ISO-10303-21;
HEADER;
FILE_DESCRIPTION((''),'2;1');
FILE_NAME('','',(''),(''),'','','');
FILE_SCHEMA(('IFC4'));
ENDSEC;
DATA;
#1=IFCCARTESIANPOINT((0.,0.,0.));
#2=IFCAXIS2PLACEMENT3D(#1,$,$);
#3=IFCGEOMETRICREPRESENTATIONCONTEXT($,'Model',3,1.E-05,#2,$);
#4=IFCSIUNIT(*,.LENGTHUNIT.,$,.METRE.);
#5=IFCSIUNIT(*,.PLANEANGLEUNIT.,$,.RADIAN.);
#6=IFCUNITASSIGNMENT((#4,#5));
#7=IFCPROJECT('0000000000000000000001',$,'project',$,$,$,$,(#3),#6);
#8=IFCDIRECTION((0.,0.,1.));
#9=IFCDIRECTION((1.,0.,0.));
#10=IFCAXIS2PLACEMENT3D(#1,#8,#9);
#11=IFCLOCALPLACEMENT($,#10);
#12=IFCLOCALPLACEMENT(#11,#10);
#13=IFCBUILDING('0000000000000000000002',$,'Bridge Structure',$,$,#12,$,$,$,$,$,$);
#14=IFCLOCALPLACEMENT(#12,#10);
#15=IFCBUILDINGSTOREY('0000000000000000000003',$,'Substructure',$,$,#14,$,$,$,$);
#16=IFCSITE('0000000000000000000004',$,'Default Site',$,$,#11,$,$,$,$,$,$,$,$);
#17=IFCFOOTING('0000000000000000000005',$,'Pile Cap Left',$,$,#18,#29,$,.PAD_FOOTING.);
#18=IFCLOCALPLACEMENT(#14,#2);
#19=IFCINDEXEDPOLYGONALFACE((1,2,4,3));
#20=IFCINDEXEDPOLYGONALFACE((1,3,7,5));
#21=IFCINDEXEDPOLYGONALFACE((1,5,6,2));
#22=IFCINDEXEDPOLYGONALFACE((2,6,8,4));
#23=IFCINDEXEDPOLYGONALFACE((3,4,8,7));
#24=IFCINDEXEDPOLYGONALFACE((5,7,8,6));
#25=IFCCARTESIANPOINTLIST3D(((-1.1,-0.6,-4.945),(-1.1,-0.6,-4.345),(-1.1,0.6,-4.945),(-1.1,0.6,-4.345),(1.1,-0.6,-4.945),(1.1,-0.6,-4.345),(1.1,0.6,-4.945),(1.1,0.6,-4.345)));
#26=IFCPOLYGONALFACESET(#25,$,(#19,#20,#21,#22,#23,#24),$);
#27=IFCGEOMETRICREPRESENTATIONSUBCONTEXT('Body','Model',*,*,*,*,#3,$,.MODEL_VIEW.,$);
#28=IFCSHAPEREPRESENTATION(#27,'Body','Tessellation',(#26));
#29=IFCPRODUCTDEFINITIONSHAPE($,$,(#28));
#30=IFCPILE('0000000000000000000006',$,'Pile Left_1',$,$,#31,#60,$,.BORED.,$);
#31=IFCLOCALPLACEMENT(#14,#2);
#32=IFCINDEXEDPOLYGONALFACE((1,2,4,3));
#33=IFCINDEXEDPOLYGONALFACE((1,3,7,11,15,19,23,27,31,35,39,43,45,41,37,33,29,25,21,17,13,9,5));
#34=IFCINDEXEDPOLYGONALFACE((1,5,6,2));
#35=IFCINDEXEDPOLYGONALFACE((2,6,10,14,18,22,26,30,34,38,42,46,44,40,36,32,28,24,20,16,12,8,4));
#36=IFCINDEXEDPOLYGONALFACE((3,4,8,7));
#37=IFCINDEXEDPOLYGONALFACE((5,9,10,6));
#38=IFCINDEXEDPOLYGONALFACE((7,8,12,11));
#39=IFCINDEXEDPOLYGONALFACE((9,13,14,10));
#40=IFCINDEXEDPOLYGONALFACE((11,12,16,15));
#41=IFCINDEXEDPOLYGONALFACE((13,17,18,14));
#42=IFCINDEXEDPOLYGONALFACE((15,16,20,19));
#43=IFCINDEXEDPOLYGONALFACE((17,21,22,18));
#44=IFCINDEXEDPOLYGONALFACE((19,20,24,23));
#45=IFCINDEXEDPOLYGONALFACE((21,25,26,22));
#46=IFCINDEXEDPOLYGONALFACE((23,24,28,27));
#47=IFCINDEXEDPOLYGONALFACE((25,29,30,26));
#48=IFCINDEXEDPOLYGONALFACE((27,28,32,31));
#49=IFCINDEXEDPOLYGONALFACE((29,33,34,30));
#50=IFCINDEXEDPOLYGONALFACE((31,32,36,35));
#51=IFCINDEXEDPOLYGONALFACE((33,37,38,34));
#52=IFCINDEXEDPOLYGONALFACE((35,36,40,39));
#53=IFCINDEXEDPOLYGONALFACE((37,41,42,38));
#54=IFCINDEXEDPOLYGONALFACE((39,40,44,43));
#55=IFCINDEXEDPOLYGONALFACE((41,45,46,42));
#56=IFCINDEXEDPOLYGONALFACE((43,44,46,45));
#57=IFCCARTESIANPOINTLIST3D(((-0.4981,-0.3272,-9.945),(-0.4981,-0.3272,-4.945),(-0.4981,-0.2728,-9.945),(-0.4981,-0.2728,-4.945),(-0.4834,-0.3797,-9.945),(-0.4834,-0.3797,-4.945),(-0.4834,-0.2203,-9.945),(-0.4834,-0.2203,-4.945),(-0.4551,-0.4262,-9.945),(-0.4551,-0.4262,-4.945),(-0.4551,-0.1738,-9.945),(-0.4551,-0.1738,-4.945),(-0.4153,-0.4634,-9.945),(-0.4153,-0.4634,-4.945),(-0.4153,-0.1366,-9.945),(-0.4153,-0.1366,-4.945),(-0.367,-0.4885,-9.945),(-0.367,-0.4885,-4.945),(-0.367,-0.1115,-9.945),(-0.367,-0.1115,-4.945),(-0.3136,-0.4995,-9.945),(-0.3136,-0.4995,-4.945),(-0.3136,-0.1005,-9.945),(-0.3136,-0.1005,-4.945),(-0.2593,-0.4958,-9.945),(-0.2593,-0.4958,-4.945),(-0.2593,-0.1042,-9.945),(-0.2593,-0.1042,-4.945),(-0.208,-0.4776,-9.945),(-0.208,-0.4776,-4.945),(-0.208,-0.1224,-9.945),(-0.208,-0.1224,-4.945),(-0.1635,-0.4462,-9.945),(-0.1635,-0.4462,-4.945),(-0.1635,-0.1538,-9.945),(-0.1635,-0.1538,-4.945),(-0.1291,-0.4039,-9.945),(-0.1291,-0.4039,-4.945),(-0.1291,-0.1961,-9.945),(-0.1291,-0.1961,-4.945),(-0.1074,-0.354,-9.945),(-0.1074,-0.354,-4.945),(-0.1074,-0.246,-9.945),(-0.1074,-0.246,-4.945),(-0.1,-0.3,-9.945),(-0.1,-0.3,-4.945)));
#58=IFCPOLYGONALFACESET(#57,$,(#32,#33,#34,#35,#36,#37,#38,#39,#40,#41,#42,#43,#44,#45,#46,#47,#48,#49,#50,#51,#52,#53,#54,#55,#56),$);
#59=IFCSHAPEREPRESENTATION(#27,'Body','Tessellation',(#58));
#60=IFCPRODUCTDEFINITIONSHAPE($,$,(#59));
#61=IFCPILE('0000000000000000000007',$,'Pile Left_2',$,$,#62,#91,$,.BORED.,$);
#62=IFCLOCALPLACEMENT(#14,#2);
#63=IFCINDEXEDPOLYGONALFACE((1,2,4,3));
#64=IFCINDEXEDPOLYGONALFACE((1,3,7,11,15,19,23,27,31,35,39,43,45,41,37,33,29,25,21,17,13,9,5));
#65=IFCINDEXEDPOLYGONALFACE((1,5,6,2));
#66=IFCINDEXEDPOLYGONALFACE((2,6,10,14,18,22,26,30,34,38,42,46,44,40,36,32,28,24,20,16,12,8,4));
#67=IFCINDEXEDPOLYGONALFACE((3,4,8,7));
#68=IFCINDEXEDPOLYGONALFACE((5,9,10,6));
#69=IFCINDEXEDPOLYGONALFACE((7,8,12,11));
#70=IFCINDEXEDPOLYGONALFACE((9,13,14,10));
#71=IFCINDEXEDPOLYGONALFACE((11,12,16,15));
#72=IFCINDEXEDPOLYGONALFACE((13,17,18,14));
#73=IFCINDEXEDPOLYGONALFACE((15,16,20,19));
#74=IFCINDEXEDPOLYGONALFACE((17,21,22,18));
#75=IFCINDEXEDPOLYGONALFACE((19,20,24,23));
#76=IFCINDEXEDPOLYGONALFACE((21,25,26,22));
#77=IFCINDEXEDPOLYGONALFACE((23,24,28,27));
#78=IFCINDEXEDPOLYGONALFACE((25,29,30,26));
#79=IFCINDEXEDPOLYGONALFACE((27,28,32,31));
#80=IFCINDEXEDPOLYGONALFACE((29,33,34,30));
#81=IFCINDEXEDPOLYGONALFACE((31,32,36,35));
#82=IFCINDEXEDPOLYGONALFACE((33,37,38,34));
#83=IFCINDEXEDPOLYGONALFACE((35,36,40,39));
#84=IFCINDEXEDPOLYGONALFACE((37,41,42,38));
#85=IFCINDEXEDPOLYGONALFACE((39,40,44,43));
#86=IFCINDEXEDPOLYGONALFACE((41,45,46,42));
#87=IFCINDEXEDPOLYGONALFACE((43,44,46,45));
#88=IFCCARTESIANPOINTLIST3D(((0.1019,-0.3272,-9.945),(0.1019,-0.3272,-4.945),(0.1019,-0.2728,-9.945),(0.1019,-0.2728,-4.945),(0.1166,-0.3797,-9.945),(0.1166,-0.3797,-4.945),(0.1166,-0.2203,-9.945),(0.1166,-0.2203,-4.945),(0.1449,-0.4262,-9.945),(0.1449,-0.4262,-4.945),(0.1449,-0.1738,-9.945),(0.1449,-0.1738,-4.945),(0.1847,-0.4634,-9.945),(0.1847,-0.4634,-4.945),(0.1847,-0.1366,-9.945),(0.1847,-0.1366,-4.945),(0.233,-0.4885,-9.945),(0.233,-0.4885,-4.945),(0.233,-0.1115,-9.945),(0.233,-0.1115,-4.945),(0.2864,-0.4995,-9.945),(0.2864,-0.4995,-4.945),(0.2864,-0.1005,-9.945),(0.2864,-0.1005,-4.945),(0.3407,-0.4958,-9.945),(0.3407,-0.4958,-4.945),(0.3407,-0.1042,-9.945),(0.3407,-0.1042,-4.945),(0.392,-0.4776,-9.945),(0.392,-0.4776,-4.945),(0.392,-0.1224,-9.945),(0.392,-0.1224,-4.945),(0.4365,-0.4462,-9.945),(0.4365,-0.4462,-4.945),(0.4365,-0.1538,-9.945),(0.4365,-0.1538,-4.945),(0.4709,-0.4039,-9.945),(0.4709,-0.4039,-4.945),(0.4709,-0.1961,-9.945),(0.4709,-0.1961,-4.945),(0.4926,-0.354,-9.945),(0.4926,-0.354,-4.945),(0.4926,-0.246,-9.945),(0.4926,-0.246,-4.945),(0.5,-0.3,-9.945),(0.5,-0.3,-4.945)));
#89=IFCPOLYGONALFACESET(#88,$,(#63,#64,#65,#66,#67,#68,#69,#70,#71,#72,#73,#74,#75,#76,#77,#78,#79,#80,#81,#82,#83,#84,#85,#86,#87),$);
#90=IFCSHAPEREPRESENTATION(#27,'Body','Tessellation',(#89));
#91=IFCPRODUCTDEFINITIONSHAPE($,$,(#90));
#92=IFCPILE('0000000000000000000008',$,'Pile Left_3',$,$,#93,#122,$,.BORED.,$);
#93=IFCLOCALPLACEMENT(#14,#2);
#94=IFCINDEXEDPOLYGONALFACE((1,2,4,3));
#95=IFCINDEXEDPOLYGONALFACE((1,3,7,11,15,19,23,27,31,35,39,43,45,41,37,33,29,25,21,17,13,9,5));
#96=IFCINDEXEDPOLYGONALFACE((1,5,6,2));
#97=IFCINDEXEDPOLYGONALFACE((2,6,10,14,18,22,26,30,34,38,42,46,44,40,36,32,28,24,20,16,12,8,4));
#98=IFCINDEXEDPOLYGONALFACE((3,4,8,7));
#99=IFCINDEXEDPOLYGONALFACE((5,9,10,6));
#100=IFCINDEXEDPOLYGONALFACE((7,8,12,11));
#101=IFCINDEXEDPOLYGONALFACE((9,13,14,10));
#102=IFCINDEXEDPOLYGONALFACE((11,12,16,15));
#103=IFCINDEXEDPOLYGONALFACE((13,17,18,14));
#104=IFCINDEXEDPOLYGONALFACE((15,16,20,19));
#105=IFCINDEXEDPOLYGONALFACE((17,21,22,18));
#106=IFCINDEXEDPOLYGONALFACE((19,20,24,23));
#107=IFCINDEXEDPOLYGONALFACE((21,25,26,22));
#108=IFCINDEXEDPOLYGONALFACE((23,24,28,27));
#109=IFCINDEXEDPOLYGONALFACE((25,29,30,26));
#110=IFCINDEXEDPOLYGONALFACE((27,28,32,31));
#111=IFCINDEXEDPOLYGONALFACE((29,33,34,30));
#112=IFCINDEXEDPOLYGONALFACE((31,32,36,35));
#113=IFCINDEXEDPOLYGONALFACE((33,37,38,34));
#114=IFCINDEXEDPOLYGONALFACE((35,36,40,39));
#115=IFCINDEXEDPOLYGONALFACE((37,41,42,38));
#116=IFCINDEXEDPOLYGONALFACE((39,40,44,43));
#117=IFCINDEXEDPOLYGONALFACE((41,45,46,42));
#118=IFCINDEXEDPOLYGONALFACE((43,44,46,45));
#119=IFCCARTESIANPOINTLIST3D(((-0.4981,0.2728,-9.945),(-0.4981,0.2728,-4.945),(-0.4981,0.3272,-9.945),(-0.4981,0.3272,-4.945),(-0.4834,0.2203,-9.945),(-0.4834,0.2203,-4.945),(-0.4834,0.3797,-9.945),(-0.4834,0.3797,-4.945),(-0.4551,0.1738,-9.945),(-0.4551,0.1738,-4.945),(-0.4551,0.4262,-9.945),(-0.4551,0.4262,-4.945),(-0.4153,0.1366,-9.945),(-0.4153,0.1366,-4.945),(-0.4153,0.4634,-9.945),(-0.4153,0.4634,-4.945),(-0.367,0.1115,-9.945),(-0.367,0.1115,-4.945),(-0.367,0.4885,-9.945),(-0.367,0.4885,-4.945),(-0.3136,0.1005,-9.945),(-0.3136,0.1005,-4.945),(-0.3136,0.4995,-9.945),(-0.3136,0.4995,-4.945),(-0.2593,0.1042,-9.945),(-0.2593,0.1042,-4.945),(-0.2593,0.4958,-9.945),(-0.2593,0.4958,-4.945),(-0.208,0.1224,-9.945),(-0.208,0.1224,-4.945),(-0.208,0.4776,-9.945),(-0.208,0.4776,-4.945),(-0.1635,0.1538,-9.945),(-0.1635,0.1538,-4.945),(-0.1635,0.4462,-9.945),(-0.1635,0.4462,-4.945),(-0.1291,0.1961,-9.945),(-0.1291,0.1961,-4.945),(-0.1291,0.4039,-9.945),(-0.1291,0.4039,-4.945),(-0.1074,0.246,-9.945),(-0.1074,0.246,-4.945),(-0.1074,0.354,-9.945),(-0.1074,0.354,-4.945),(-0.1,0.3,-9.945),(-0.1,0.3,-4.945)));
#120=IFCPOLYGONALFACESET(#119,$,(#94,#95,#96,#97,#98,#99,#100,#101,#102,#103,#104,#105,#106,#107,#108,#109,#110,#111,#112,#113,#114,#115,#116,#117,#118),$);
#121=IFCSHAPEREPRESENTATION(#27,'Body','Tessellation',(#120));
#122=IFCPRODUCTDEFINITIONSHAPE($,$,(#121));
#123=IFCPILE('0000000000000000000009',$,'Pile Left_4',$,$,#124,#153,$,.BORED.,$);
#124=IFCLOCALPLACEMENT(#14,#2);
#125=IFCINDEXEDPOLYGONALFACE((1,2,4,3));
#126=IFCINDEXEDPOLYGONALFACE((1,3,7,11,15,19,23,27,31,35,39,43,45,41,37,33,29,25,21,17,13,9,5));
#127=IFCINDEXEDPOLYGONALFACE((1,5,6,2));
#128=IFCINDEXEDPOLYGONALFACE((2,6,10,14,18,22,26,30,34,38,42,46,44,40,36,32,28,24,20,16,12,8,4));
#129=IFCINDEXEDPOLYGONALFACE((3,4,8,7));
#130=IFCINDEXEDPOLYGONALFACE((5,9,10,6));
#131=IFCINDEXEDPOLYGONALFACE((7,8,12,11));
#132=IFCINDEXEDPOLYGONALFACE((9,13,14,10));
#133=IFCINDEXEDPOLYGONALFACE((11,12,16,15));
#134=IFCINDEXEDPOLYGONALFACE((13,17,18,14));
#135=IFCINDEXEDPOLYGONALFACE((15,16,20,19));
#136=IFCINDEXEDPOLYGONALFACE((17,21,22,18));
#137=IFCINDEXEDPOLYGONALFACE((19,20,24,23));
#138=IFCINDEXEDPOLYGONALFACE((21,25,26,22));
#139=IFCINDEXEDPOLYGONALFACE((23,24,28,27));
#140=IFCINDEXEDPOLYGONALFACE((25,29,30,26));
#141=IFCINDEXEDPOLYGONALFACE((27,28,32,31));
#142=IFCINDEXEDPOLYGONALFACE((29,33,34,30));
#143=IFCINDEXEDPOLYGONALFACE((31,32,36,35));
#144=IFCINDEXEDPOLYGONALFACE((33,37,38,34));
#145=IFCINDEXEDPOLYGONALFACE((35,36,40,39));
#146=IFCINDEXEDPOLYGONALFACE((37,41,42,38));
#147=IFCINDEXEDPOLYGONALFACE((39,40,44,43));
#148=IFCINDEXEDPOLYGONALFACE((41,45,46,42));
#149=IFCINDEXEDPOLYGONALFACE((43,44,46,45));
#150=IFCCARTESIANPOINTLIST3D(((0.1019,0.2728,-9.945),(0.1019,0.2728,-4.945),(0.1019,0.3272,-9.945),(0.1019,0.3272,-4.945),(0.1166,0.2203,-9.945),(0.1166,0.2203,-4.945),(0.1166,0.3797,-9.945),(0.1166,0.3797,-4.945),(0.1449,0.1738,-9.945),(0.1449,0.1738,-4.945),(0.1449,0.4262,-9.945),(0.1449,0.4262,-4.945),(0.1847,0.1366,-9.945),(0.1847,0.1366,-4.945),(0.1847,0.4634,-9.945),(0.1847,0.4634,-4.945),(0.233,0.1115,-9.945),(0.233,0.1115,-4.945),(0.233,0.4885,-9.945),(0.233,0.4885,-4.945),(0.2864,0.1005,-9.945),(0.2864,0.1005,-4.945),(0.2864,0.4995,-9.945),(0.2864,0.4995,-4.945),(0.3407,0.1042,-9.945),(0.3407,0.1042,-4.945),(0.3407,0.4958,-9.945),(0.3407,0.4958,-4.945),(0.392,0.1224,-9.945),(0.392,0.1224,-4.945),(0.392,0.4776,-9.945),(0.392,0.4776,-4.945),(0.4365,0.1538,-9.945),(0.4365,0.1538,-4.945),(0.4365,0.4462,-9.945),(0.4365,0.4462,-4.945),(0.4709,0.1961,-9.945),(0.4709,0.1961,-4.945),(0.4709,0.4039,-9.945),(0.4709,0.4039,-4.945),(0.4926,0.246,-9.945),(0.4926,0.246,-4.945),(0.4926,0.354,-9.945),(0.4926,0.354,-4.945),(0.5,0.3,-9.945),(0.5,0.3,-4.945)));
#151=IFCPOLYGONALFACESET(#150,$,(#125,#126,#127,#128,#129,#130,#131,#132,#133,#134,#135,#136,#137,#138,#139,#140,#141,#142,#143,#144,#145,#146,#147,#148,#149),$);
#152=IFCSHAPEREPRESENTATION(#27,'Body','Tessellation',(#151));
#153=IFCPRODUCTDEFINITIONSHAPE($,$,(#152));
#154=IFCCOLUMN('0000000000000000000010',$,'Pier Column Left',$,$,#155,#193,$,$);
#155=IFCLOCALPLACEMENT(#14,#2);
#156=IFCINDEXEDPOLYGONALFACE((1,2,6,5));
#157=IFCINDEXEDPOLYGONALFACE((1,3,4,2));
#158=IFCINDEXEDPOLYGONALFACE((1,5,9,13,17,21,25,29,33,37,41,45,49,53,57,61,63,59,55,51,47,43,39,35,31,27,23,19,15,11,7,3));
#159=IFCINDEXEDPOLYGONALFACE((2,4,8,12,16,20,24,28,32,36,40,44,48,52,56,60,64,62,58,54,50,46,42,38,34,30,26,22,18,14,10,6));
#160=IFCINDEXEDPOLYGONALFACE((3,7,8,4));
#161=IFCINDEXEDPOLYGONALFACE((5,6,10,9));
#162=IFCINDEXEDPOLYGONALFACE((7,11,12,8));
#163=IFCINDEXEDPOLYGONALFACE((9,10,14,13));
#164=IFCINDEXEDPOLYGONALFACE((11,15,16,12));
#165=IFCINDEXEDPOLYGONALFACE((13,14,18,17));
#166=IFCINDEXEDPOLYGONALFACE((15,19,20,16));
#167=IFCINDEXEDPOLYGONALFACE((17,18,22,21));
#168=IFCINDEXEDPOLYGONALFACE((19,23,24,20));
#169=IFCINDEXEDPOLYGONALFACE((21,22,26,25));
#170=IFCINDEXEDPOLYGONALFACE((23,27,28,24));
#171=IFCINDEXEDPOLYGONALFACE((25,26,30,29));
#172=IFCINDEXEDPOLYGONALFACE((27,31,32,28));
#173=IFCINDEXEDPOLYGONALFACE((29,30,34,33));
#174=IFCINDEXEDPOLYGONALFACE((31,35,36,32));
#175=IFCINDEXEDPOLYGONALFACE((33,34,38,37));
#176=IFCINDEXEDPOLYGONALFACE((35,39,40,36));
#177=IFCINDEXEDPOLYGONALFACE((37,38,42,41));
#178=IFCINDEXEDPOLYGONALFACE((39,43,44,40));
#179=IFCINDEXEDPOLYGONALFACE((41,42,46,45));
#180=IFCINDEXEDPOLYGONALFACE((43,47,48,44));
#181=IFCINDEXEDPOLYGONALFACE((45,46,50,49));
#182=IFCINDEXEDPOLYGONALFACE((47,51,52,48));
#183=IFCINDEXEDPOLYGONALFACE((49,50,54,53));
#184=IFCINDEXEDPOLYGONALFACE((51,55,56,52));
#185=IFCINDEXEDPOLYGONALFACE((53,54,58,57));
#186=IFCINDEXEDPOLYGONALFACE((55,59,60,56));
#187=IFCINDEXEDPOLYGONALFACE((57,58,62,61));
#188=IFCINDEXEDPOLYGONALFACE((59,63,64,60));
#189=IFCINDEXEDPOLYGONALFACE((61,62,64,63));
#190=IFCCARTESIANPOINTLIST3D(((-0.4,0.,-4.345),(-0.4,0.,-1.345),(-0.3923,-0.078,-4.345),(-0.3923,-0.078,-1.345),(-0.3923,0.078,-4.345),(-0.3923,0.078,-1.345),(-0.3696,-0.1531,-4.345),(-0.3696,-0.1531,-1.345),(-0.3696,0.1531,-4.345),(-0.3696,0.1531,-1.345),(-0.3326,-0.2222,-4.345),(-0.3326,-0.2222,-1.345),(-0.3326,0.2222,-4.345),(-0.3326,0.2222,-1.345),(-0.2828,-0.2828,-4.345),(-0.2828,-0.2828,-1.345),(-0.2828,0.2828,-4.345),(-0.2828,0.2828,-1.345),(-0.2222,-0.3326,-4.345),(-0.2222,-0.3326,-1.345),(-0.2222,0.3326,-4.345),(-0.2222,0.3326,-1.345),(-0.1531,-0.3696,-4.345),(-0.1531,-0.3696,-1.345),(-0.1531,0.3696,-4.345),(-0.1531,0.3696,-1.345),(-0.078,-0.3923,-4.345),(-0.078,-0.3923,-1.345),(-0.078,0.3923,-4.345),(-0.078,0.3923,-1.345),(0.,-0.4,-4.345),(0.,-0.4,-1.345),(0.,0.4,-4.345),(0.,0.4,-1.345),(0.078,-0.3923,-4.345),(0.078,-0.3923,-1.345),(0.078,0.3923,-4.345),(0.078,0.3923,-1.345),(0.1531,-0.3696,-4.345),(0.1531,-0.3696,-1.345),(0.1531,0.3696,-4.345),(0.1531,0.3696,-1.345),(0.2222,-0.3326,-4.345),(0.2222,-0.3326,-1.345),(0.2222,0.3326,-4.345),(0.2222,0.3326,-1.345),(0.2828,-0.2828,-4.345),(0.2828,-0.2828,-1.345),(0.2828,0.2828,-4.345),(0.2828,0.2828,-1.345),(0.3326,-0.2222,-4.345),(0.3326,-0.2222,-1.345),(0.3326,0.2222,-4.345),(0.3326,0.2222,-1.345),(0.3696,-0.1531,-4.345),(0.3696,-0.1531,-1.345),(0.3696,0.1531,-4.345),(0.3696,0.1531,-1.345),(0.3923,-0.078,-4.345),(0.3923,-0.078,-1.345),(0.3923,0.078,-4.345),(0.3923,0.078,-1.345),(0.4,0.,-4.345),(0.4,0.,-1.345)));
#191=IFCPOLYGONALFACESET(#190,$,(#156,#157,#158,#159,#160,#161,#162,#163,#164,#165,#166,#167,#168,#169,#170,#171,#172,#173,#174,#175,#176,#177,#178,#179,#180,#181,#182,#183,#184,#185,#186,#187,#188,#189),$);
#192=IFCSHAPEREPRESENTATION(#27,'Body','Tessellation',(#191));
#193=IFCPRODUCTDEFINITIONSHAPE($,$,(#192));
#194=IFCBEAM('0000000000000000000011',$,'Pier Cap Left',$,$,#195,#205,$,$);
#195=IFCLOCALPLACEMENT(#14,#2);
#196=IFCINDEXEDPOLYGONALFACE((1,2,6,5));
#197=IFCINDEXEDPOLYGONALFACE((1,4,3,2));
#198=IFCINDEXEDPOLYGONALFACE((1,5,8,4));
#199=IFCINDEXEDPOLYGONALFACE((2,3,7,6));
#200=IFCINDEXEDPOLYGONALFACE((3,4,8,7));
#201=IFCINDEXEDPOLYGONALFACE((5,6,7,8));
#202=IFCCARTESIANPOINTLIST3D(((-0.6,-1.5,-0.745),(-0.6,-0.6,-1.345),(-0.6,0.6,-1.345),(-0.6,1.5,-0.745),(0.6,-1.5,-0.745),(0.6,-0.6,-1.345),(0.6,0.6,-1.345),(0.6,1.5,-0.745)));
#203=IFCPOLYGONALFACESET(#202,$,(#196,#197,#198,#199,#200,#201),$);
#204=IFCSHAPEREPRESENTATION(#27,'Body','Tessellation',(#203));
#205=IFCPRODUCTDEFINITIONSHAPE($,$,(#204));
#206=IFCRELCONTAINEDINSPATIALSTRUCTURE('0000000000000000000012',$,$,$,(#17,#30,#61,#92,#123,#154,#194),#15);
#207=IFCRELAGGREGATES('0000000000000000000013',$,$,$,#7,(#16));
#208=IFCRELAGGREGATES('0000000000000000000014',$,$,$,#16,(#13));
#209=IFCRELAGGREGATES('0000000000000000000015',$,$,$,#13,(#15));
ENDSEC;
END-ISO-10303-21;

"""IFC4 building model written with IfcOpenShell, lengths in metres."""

from ifc_helpers import new_model, si_unit, frame, origin, origin_with_axes, origin_2d_with_axis, place, context, subcontext, project, spatial, polyline, rectangle, circle, outline, extrude, element, save


model = new_model("IFC4")

# Units and contexts
model_context = context("Model", 3, precision=1e-05, world=origin())
body_context = subcontext(model_context, "Body", "Model", "MODEL_VIEW")
ifc_project = project(units=[si_unit("LENGTHUNIT", "METRE"), si_unit("PLANEANGLEUNIT", "RADIAN")], contexts=[model_context])

# Site, building, storey
site_placement = place(None, origin_with_axes())
site = spatial("IfcSite", under=ifc_project, at=site_placement, Name="Default Site")
building_placement = place(site_placement, origin_with_axes())
building = spatial("IfcBuilding", under=site, at=building_placement, Name="Bridge Structure")
storey_placement = place(building_placement, origin_with_axes())
storey = spatial("IfcBuildingStorey", under=building, at=storey_placement, Name="Substructure")

# Footing
footing_placement = place(storey_placement, frame((0.0, 0.0, -4.945), z_axis=(0.0, 0.0, 1.0), x_axis=(1.0, 0.0, 0.0)))
element("IfcFooting", 1, at=footing_placement, inside=storey, Name="Pile Cap Left", PredefinedType="PAD_FOOTING", context=body_context, shape_type="SweptSolid", body=[
    extrude(rectangle(XDim=2.2, YDim=1.2, at=origin_2d_with_axis()), origin_with_axes(), (0.0, 0.0, 1.0), 0.6),
])

# Piles
for number, where, z_axis, x_axis, name in (
    (2, (-0.3, -0.3, -9.945), (0.0, 0.0, 1.0), (1.0, 0.0, 0.0), "Pile Left_1"),
    (3, (0.3, -0.3, -9.945), (0.0, 0.0, 1.0), (1.0, 0.0, 0.0), "Pile Left_2"),
    (4, (-0.3, 0.3, -9.945), (0.0, 0.0, 1.0), (1.0, 0.0, 0.0), "Pile Left_3"),
    (5, (0.3, 0.3, -9.945), (0.0, 0.0, 1.0), (1.0, 0.0, 0.0), "Pile Left_4"),
):
    element("IfcPile", number, at=place(storey_placement, frame(where, z_axis=z_axis, x_axis=x_axis)), inside=storey, Name=name, PredefinedType="BORED", context=body_context, shape_type="SweptSolid", body=[
        extrude(circle(Radius=0.2, at=origin_2d_with_axis()), origin_with_axes(), (0.0, 0.0, 1.0), 5.0),
    ])

# Column
column_placement = place(storey_placement, frame((0.0, 0.0, -4.345), z_axis=(0.0, 0.0, 1.0), x_axis=(1.0, 0.0, 0.0)))
element("IfcColumn", 6, at=column_placement, inside=storey, Name="Pier Column Left", context=body_context, shape_type="SweptSolid", body=[
    extrude(circle(Radius=0.4, at=origin_2d_with_axis()), origin_with_axes(), (0.0, 0.0, 1.0), 3.0),
])

# Beam
beam_placement = place(storey_placement, frame((-0.6, 0.0, -1.345), z_axis=(1.0, 0.0, 0.0), x_axis=(0.0, 1.0, 0.0)))
element("IfcBeam", 7, at=beam_placement, inside=storey, Name="Pier Cap Left", context=body_context, shape_type="SweptSolid", body=[
    extrude(outline(polyline([(-1.5, 0.6), (1.5, 0.6), (0.6, 0.0), (-0.6, 0.0), (-1.5, 0.6)])), origin_with_axes(), (0.0, 0.0, 1.0), 1.2),
])

save(model, "model.ifc")
